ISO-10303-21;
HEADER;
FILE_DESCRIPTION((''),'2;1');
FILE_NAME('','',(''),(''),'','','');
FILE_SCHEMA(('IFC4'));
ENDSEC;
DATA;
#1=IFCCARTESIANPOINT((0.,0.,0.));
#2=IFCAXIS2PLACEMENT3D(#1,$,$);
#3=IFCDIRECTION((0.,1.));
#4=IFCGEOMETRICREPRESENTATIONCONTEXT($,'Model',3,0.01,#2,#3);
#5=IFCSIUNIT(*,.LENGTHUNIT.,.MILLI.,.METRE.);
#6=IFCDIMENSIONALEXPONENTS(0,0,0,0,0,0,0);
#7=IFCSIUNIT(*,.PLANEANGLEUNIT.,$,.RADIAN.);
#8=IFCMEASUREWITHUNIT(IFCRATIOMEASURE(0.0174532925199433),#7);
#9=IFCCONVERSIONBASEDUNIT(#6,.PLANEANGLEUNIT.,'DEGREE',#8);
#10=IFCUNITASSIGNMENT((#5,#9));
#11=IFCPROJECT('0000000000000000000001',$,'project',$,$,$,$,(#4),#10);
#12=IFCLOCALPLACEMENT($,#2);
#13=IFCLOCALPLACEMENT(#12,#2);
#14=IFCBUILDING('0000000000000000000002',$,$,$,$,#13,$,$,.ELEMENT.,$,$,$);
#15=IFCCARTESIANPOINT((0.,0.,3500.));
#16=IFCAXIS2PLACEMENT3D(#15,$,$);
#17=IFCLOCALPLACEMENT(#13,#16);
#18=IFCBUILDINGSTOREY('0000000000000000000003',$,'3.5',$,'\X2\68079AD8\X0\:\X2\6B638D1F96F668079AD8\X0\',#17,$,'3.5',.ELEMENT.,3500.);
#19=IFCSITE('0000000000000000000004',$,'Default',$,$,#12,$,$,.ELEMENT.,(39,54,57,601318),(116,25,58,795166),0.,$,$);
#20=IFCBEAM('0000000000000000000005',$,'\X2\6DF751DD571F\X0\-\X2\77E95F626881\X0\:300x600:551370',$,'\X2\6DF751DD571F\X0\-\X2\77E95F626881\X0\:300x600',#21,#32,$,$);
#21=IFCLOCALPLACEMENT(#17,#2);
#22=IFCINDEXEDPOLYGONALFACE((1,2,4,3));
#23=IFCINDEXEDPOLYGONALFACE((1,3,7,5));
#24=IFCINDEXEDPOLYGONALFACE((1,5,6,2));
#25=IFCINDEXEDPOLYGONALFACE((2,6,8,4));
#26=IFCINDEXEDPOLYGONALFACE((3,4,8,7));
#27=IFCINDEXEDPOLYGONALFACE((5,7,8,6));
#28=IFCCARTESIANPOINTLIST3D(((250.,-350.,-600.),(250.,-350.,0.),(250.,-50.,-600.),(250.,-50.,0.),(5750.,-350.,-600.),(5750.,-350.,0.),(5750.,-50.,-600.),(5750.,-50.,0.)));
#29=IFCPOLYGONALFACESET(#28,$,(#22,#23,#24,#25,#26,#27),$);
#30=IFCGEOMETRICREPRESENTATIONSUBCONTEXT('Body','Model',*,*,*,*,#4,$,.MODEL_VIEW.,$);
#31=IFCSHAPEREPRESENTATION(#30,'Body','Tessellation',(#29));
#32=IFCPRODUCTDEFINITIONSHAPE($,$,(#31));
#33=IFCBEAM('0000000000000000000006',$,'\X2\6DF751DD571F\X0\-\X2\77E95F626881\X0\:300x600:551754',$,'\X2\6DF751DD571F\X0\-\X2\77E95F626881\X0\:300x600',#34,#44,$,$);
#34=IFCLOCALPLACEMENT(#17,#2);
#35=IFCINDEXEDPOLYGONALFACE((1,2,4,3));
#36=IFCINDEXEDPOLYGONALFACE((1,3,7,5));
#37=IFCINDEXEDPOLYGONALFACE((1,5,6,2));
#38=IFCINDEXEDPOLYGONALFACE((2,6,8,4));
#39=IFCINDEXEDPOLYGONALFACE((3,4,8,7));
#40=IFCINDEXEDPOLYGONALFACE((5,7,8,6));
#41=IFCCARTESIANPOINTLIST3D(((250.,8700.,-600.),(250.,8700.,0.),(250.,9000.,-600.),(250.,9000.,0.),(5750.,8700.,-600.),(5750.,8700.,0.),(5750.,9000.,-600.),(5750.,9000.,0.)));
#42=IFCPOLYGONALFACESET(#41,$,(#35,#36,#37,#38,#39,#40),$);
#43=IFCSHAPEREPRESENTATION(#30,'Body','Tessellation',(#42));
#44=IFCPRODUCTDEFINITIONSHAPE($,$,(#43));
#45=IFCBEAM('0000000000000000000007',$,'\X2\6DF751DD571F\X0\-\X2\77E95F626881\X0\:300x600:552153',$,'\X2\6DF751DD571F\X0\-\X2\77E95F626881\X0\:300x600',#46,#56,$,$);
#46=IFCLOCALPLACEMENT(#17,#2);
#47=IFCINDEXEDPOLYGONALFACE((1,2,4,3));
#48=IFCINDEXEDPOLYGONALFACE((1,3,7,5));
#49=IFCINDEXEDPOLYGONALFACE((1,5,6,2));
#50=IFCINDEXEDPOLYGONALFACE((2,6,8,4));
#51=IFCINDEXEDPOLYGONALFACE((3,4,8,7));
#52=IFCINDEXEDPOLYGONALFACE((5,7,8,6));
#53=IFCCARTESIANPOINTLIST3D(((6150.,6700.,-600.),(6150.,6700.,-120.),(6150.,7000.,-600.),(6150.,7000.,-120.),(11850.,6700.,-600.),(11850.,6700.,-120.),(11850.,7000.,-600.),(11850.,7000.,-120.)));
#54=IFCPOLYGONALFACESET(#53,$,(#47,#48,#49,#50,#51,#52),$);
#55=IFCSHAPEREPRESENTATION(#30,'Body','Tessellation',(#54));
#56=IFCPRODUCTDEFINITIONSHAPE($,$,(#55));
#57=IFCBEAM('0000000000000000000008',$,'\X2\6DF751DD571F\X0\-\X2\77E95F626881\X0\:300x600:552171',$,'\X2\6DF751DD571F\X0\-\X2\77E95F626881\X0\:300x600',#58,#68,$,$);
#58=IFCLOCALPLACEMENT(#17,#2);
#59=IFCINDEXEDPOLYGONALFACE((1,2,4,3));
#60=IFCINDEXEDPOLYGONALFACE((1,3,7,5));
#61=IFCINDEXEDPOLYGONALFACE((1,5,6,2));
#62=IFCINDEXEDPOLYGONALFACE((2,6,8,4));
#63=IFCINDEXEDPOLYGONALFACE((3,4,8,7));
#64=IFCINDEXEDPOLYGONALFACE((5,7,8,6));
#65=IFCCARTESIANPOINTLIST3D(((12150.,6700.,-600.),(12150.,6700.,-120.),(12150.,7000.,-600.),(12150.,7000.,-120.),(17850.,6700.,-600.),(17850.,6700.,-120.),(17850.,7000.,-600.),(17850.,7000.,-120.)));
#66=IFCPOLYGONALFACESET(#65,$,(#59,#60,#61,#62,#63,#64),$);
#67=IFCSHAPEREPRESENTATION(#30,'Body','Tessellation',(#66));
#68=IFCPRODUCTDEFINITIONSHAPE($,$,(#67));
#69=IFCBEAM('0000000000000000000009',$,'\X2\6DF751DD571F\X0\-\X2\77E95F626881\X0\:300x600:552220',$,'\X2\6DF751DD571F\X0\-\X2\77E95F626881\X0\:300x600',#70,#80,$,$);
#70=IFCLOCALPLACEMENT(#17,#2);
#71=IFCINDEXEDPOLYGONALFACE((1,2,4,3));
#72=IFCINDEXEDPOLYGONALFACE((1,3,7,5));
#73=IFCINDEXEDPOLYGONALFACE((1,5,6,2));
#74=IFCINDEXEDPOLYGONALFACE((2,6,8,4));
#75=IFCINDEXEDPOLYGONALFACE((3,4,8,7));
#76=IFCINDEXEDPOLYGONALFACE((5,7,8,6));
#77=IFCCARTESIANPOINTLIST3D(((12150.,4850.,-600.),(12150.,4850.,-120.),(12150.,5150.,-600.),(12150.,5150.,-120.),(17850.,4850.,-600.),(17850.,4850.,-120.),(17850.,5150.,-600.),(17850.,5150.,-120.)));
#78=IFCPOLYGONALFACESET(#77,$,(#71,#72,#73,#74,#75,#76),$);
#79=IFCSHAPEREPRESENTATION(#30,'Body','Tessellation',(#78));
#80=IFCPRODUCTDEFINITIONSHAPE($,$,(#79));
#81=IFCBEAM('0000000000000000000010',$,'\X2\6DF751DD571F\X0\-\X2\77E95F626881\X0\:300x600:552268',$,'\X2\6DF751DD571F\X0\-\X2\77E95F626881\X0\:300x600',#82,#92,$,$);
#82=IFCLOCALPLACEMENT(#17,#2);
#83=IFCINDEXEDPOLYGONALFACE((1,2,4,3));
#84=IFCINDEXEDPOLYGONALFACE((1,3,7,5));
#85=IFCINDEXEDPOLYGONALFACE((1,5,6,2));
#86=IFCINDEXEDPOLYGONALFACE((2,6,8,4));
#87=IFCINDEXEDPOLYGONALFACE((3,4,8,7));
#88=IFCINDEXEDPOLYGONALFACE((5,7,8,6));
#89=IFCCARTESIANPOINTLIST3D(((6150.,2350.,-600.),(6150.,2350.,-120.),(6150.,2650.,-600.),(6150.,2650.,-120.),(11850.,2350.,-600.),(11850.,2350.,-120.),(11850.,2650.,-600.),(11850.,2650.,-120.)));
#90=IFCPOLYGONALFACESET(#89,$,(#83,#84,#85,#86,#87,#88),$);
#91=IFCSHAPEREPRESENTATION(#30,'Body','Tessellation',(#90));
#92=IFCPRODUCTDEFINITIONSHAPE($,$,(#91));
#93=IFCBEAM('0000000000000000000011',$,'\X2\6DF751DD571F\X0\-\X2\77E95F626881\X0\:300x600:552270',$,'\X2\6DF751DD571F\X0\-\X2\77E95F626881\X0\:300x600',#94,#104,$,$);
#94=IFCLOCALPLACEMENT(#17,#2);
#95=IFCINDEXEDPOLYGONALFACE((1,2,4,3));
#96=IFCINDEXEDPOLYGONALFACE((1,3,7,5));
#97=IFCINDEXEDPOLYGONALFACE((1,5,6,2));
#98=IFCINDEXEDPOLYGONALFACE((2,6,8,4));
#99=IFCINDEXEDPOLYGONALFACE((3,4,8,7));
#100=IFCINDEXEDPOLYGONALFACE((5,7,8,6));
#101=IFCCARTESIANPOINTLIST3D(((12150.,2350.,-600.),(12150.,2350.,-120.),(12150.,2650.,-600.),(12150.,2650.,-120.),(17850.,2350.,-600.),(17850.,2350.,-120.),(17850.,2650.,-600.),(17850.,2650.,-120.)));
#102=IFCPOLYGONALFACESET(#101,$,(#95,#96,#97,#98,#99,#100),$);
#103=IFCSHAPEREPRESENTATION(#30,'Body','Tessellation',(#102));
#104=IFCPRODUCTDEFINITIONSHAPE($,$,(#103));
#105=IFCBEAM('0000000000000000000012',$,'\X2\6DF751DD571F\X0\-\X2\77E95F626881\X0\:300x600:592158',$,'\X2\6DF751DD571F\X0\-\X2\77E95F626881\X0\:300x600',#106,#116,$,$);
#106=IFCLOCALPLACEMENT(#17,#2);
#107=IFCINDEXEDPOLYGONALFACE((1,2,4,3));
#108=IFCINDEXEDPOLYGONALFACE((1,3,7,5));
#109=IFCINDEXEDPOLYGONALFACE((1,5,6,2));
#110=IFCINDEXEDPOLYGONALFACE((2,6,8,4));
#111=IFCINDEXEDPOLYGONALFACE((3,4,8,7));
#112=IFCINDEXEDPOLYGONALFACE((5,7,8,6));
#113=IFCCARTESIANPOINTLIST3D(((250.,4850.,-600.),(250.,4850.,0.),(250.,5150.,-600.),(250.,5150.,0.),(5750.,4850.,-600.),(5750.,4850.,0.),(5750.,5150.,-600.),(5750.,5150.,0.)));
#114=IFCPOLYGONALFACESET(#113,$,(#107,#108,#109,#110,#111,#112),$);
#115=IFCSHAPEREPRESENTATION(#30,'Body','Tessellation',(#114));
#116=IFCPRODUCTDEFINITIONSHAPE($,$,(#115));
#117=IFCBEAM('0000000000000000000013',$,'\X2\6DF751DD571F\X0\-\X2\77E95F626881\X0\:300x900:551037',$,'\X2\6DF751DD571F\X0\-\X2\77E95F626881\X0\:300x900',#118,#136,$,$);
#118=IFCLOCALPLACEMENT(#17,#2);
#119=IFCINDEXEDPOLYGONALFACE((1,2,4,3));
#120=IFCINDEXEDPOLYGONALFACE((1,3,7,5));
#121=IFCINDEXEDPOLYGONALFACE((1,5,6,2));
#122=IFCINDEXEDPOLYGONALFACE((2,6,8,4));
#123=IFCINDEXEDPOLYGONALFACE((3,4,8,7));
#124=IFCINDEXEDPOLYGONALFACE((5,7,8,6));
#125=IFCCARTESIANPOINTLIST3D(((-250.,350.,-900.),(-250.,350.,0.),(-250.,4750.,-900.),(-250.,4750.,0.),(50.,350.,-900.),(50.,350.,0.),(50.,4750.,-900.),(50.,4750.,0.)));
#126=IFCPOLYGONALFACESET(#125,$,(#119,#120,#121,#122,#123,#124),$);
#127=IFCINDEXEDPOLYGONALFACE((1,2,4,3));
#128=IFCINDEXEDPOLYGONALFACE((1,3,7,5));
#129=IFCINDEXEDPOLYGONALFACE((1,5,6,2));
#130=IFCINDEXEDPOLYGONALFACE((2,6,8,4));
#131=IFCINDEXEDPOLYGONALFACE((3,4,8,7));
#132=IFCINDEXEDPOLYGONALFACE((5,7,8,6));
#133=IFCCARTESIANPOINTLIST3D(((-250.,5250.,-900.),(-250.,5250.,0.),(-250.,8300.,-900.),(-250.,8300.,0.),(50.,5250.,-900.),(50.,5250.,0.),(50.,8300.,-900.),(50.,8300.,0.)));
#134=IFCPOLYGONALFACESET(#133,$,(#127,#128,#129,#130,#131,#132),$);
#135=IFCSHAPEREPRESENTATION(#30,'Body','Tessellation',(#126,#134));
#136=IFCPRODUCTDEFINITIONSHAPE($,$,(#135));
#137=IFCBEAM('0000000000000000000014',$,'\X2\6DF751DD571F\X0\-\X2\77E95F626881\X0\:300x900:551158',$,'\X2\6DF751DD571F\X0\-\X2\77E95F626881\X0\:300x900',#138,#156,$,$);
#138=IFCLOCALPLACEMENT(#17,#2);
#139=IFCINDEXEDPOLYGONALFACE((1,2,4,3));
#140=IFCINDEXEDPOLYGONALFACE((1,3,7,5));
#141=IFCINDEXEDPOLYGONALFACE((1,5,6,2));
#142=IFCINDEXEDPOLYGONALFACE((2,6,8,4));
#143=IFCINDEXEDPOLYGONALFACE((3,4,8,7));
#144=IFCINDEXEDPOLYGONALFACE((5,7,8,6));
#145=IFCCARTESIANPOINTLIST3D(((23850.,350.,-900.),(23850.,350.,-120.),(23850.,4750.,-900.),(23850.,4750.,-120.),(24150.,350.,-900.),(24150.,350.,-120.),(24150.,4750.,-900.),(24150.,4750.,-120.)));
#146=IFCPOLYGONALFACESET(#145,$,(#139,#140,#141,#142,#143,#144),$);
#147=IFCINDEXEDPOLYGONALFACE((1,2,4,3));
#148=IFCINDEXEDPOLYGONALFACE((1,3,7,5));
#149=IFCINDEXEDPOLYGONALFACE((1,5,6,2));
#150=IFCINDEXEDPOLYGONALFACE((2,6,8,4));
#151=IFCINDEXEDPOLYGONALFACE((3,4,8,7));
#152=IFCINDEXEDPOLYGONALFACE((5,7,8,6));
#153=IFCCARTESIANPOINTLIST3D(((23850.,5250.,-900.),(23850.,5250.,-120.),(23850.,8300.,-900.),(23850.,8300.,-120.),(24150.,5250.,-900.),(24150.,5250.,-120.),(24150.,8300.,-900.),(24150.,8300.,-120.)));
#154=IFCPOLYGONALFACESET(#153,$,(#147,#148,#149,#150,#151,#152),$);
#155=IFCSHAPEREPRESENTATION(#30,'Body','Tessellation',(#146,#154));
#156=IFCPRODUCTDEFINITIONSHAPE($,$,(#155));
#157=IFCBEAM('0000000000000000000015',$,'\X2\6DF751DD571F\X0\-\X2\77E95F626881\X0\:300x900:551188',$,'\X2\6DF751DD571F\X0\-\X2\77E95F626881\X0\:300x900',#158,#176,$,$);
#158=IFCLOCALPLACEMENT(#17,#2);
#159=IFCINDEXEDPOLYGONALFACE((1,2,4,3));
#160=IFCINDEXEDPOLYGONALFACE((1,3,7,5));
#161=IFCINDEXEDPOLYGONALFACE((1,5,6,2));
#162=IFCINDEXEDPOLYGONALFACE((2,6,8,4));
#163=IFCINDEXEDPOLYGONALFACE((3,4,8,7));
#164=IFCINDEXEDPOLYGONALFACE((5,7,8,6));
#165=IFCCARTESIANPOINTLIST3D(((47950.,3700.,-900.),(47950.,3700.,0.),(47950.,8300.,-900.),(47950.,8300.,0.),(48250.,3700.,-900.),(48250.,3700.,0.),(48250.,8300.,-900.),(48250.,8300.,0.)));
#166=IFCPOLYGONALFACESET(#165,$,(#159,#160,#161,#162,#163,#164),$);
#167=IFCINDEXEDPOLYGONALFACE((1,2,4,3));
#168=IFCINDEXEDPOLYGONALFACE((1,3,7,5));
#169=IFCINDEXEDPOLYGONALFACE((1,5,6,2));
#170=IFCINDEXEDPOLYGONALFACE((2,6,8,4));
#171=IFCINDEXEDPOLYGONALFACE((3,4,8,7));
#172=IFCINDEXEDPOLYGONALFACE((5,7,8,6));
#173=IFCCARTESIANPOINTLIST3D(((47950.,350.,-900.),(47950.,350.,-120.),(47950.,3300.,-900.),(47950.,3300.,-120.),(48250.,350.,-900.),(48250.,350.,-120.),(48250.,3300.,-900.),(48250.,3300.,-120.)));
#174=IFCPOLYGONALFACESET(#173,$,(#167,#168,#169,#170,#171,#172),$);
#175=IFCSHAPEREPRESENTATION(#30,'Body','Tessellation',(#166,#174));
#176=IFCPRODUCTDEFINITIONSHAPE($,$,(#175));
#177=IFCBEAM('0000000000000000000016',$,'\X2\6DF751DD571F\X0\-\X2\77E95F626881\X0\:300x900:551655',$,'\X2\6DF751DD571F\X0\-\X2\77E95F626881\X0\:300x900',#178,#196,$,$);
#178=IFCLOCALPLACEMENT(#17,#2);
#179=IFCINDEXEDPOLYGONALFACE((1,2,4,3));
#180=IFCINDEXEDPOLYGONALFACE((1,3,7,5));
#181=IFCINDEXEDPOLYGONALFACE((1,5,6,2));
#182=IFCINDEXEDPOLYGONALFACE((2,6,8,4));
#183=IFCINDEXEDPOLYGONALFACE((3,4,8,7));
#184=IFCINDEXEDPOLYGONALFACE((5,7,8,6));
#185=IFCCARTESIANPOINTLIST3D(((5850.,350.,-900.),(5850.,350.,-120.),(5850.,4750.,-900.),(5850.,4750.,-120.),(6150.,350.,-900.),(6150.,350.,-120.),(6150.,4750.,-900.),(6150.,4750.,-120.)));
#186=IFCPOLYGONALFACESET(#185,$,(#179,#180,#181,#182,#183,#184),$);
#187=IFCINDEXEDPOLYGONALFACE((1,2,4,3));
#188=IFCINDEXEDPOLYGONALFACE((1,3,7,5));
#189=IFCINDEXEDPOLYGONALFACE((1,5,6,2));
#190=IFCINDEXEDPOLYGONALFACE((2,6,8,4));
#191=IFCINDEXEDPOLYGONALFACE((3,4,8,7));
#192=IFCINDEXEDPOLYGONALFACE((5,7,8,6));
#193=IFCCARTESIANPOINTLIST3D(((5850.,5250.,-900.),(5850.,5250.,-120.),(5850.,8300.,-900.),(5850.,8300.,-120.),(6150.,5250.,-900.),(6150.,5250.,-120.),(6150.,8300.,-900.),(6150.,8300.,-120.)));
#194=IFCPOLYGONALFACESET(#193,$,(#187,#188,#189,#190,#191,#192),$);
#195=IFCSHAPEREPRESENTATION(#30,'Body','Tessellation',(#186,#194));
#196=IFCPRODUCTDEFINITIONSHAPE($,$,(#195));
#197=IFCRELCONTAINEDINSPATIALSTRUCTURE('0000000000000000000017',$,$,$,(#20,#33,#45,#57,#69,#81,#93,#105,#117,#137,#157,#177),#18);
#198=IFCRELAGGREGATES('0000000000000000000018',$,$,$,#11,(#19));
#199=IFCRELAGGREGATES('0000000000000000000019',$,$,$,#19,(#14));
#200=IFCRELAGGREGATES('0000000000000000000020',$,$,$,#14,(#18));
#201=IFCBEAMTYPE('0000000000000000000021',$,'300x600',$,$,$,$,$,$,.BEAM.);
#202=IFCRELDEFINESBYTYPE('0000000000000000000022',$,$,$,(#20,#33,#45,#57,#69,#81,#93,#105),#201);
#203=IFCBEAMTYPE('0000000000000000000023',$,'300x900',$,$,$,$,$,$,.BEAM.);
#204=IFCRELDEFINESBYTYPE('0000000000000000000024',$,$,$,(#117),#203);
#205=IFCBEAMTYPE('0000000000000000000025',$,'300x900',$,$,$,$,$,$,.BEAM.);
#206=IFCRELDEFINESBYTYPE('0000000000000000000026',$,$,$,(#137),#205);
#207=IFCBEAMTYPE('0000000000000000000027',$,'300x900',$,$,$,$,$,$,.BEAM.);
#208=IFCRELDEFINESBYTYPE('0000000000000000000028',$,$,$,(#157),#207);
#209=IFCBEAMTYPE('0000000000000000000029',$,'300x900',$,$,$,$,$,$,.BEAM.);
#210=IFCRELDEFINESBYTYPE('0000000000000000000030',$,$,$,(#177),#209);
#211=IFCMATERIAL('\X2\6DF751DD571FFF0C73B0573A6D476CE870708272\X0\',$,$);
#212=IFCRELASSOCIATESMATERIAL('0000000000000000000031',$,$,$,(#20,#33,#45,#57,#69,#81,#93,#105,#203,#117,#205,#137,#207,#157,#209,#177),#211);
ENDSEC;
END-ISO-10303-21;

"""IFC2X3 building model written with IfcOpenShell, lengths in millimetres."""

from ifc_helpers import new_model, entity, si_unit, converted_unit, direction, frame, frame_2d, origin, place, context, subcontext, project, spatial, rectangle, extrude, source, transform, mapped, material, type_object, type_shapes, element, save


model = new_model("IFC2X3")

# Units and contexts
model_context = context("Model", 3, precision=0.01, world=origin(), true_north=direction((0.0, 1.0)))
body_context = subcontext(model_context, "Body", "Model", "MODEL_VIEW")
ifc_project = project(units=[si_unit("LENGTHUNIT", "METRE", prefix="MILLI"), converted_unit("PLANEANGLEUNIT", "DEGREE", entity("IfcRatioMeasure", 0.0174532925199433), si_unit("PLANEANGLEUNIT", "RADIAN"), dimensions=[0, 0, 0, 0, 0, 0, 0])], contexts=[model_context])

# Site, building, storey
site_placement = place(None, origin())
site = spatial("IfcSite", under=ifc_project, at=site_placement, Name="Default", CompositionType="ELEMENT", RefLatitude=(39, 54, 57, 601318), RefLongitude=(116, 25, 58, 795166), RefElevation=0.0)
building_placement = place(site_placement, origin())
building = spatial("IfcBuilding", under=site, at=building_placement, CompositionType="ELEMENT")
storey_placement = place(building_placement, frame((0.0, 0.0, 3500.0)))
storey = spatial("IfcBuildingStorey", under=building, at=storey_placement, Name="3.5", ObjectType="标高:正负零标高", LongName="3.5", CompositionType="ELEMENT", Elevation=3500.0)

# Beams
ifc_material_1 = material(Name="混凝土，现场浇注灰色")
beam_type_1 = type_object("IfcBeamType", Name="300x600", PredefinedType="BEAM")
beam_1_placement = place(storey_placement, frame((0.0, -200.0, 0.0)))
element("IfcBeam", 1, at=beam_1_placement, inside=storey, type_object=beam_type_1, material=ifc_material_1, Name="混凝土-矩形梁:300x600:551370", ObjectType="混凝土-矩形梁:300x600", context=body_context, shape_type="SweptSolid", body=[
    extrude(rectangle(XDim=600.0, YDim=300.0, at=frame_2d((0.0, 0.0), x_axis=(1.0, 0.0))), frame((250.0, 0.0, -300.0), z_axis=(1.0, 0.0, 0.0), x_axis=(0.0, 0.0, -1.0)), (0.0, 0.0, 1.0), 5500.0),
])
beam_2_placement = place(storey_placement, frame((0.0, 8850.0, 0.0)))
element("IfcBeam", 2, at=beam_2_placement, inside=storey, type_object=beam_type_1, material=ifc_material_1, Name="混凝土-矩形梁:300x600:551754", ObjectType="混凝土-矩形梁:300x600", context=body_context, shape_type="SweptSolid", body=[
    extrude(rectangle(XDim=600.0, YDim=300.0, at=frame_2d((0.0, 0.0), x_axis=(1.0, 0.0))), frame((250.0, 0.0, -300.0), z_axis=(1.0, 0.0, 0.0), x_axis=(0.0, 0.0, -1.0)), (0.0, 0.0, 1.0), 5500.0),
])
beam_3_placement = place(storey_placement, frame((6000.0, 6850.0, 0.0)))
element("IfcBeam", 3, at=beam_3_placement, inside=storey, type_object=beam_type_1, material=ifc_material_1, Name="混凝土-矩形梁:300x600:552153", ObjectType="混凝土-矩形梁:300x600", context=body_context, shape_type="SweptSolid", body=[
    extrude(rectangle(XDim=480.0, YDim=300.0, at=frame_2d((0.0, 0.0), x_axis=(1.0, 0.0))), frame((150.0, 0.0, -360.0), z_axis=(1.0, 0.0, 0.0), x_axis=(0.0, 0.0, -1.0)), (0.0, 0.0, 1.0), 5700.0),
])
beam_4_placement = place(storey_placement, frame((12000.0, 6850.0, 0.0)))
element("IfcBeam", 4, at=beam_4_placement, inside=storey, type_object=beam_type_1, material=ifc_material_1, Name="混凝土-矩形梁:300x600:552171", ObjectType="混凝土-矩形梁:300x600", context=body_context, shape_type="SweptSolid", body=[
    extrude(rectangle(XDim=480.0, YDim=300.0, at=frame_2d((0.0, 0.0), x_axis=(1.0, 0.0))), frame((150.0, 0.0, -360.0), z_axis=(1.0, 0.0, 0.0), x_axis=(0.0, 0.0, -1.0)), (0.0, 0.0, 1.0), 5700.0),
])
beam_5_placement = place(storey_placement, frame((12000.0, 5000.0, 0.0)))
element("IfcBeam", 5, at=beam_5_placement, inside=storey, type_object=beam_type_1, material=ifc_material_1, Name="混凝土-矩形梁:300x600:552220", ObjectType="混凝土-矩形梁:300x600", context=body_context, shape_type="SweptSolid", body=[
    extrude(rectangle(XDim=480.0, YDim=300.0, at=frame_2d((0.0, 0.0), x_axis=(1.0, 0.0))), frame((150.0, 0.0, -360.0), z_axis=(1.0, 0.0, 0.0), x_axis=(0.0, 0.0, -1.0)), (0.0, 0.0, 1.0), 5700.0),
])
beam_6_placement = place(storey_placement, frame((6000.0, 2500.0, 0.0)))
element("IfcBeam", 6, at=beam_6_placement, inside=storey, type_object=beam_type_1, material=ifc_material_1, Name="混凝土-矩形梁:300x600:552268", ObjectType="混凝土-矩形梁:300x600", context=body_context, shape_type="SweptSolid", body=[
    extrude(rectangle(XDim=480.0, YDim=300.0, at=frame_2d((0.0, 0.0), x_axis=(1.0, 0.0))), frame((150.0, 0.0, -360.0), z_axis=(1.0, 0.0, 0.0), x_axis=(0.0, 0.0, -1.0)), (0.0, 0.0, 1.0), 5700.0),
])
beam_7_placement = place(storey_placement, frame((12000.0, 2500.0, 0.0)))
element("IfcBeam", 7, at=beam_7_placement, inside=storey, type_object=beam_type_1, material=ifc_material_1, Name="混凝土-矩形梁:300x600:552270", ObjectType="混凝土-矩形梁:300x600", context=body_context, shape_type="SweptSolid", body=[
    extrude(rectangle(XDim=480.0, YDim=300.0, at=frame_2d((0.0, 0.0), x_axis=(1.0, 0.0))), frame((150.0, 0.0, -360.0), z_axis=(1.0, 0.0, 0.0), x_axis=(0.0, 0.0, -1.0)), (0.0, 0.0, 1.0), 5700.0),
])
beam_8_placement = place(storey_placement, frame((0.0, 5000.0, 0.0)))
element("IfcBeam", 8, at=beam_8_placement, inside=storey, type_object=beam_type_1, material=ifc_material_1, Name="混凝土-矩形梁:300x600:592158", ObjectType="混凝土-矩形梁:300x600", context=body_context, shape_type="SweptSolid", body=[
    extrude(rectangle(XDim=600.0, YDim=300.0, at=frame_2d((0.0, 0.0), x_axis=(1.0, 0.0))), frame((250.0, 0.0, -300.0), z_axis=(1.0, 0.0, 0.0), x_axis=(0.0, 0.0, -1.0)), (0.0, 0.0, 1.0), 5500.0),
])
beam_type_2 = type_object("IfcBeamType", Name="300x900", PredefinedType="BEAM", material=ifc_material_1)
shared_shape_1 = source(origin(), body_context, "Body", "SweptSolid", [
    extrude(rectangle(XDim=900.0, YDim=300.0, at=frame_2d((0.0, 0.0), x_axis=(0.0, 1.0))), frame((-100.0, 4750.0, 3050.0), z_axis=(0.0, -1.0, 0.0), x_axis=(-1.0, 0.0, 0.0)), (0.0, 0.0, 1.0), 4400.0),
    extrude(rectangle(XDim=900.0, YDim=300.0, at=frame_2d((0.0, 0.0), x_axis=(0.0, 1.0))), frame((-100.0, 8300.0, 3050.0), z_axis=(0.0, -1.0, 0.0), x_axis=(-1.0, 0.0, 0.0)), (0.0, 0.0, 1.0), 3050.0),
])
type_shapes(beam_type_2, [shared_shape_1])
beam_9_placement = place(storey_placement, frame((0.0, 0.0, -3500.0)))
element("IfcBeam", 9, at=beam_9_placement, inside=storey, type_object=beam_type_2, material=ifc_material_1, Name="混凝土-矩形梁:300x900:551037", ObjectType="混凝土-矩形梁:300x900", context=body_context, shape_type="MappedRepresentation", body=[
    mapped(shared_shape_1, transform((0.0, 0.0, 0.0), scale=1.0)),
])
beam_type_3 = type_object("IfcBeamType", Name="300x900", PredefinedType="BEAM", material=ifc_material_1)
shared_shape_2 = source(origin(), body_context, "Body", "SweptSolid", [
    extrude(rectangle(XDim=780.0, YDim=300.0, at=frame_2d((0.0, 0.0), x_axis=(0.0, 1.0))), frame((24000.0, 4750.0, 2990.0), z_axis=(0.0, -1.0, 0.0), x_axis=(-1.0, 0.0, 0.0)), (0.0, 0.0, 1.0), 4400.0),
    extrude(rectangle(XDim=780.0, YDim=300.0, at=frame_2d((0.0, 0.0), x_axis=(0.0, 1.0))), frame((24000.0, 8300.0, 2990.0), z_axis=(0.0, -1.0, 0.0), x_axis=(-1.0, 0.0, 0.0)), (0.0, 0.0, 1.0), 3050.0),
])
type_shapes(beam_type_3, [shared_shape_2])
beam_10_placement = place(storey_placement, frame((0.0, 0.0, -3500.0)))
element("IfcBeam", 10, at=beam_10_placement, inside=storey, type_object=beam_type_3, material=ifc_material_1, Name="混凝土-矩形梁:300x900:551158", ObjectType="混凝土-矩形梁:300x900", context=body_context, shape_type="MappedRepresentation", body=[
    mapped(shared_shape_2, transform((0.0, 0.0, 0.0), scale=1.0)),
])
beam_type_4 = type_object("IfcBeamType", Name="300x900", PredefinedType="BEAM", material=ifc_material_1)
shared_shape_3 = source(origin(), body_context, "Body", "SweptSolid", [
    extrude(rectangle(XDim=900.0, YDim=300.0, at=frame_2d((0.0, 0.0), x_axis=(0.0, 1.0))), frame((48100.0, 8300.0, 3050.0), z_axis=(0.0, -1.0, 0.0), x_axis=(-1.0, 0.0, 0.0)), (0.0, 0.0, 1.0), 4600.0),
    extrude(rectangle(XDim=780.0, YDim=300.0, at=frame_2d((0.0, 0.0), x_axis=(0.0, 1.0))), frame((48100.0, 3300.0, 2990.0), z_axis=(0.0, -1.0, 0.0), x_axis=(-1.0, 0.0, 0.0)), (0.0, 0.0, 1.0), 2950.0),
])
type_shapes(beam_type_4, [shared_shape_3])
beam_11_placement = place(storey_placement, frame((0.0, 0.0, -3500.0)))
element("IfcBeam", 11, at=beam_11_placement, inside=storey, type_object=beam_type_4, material=ifc_material_1, Name="混凝土-矩形梁:300x900:551188", ObjectType="混凝土-矩形梁:300x900", context=body_context, shape_type="MappedRepresentation", body=[
    mapped(shared_shape_3, transform((0.0, 0.0, 0.0), scale=1.0)),
])
beam_type_5 = type_object("IfcBeamType", Name="300x900", PredefinedType="BEAM", material=ifc_material_1)
shared_shape_4 = source(origin(), body_context, "Body", "SweptSolid", [
    extrude(rectangle(XDim=780.0, YDim=300.0, at=frame_2d((0.0, 0.0), x_axis=(0.0, 1.0))), frame((6000.0, 4750.0, 2990.0), z_axis=(0.0, -1.0, 0.0), x_axis=(-1.0, 0.0, 0.0)), (0.0, 0.0, 1.0), 4400.0),
    extrude(rectangle(XDim=780.0, YDim=300.0, at=frame_2d((0.0, 0.0), x_axis=(0.0, 1.0))), frame((6000.0, 8300.0, 2990.0), z_axis=(0.0, -1.0, 0.0), x_axis=(-1.0, 0.0, 0.0)), (0.0, 0.0, 1.0), 3050.0),
])
type_shapes(beam_type_5, [shared_shape_4])
beam_12_placement = place(storey_placement, frame((0.0, 0.0, -3500.0)))
element("IfcBeam", 12, at=beam_12_placement, inside=storey, type_object=beam_type_5, material=ifc_material_1, Name="混凝土-矩形梁:300x900:551655", ObjectType="混凝土-矩形梁:300x900", context=body_context, shape_type="MappedRepresentation", body=[
    mapped(shared_shape_4, transform((0.0, 0.0, 0.0), scale=1.0)),
])

save(model, "model.ifc")
